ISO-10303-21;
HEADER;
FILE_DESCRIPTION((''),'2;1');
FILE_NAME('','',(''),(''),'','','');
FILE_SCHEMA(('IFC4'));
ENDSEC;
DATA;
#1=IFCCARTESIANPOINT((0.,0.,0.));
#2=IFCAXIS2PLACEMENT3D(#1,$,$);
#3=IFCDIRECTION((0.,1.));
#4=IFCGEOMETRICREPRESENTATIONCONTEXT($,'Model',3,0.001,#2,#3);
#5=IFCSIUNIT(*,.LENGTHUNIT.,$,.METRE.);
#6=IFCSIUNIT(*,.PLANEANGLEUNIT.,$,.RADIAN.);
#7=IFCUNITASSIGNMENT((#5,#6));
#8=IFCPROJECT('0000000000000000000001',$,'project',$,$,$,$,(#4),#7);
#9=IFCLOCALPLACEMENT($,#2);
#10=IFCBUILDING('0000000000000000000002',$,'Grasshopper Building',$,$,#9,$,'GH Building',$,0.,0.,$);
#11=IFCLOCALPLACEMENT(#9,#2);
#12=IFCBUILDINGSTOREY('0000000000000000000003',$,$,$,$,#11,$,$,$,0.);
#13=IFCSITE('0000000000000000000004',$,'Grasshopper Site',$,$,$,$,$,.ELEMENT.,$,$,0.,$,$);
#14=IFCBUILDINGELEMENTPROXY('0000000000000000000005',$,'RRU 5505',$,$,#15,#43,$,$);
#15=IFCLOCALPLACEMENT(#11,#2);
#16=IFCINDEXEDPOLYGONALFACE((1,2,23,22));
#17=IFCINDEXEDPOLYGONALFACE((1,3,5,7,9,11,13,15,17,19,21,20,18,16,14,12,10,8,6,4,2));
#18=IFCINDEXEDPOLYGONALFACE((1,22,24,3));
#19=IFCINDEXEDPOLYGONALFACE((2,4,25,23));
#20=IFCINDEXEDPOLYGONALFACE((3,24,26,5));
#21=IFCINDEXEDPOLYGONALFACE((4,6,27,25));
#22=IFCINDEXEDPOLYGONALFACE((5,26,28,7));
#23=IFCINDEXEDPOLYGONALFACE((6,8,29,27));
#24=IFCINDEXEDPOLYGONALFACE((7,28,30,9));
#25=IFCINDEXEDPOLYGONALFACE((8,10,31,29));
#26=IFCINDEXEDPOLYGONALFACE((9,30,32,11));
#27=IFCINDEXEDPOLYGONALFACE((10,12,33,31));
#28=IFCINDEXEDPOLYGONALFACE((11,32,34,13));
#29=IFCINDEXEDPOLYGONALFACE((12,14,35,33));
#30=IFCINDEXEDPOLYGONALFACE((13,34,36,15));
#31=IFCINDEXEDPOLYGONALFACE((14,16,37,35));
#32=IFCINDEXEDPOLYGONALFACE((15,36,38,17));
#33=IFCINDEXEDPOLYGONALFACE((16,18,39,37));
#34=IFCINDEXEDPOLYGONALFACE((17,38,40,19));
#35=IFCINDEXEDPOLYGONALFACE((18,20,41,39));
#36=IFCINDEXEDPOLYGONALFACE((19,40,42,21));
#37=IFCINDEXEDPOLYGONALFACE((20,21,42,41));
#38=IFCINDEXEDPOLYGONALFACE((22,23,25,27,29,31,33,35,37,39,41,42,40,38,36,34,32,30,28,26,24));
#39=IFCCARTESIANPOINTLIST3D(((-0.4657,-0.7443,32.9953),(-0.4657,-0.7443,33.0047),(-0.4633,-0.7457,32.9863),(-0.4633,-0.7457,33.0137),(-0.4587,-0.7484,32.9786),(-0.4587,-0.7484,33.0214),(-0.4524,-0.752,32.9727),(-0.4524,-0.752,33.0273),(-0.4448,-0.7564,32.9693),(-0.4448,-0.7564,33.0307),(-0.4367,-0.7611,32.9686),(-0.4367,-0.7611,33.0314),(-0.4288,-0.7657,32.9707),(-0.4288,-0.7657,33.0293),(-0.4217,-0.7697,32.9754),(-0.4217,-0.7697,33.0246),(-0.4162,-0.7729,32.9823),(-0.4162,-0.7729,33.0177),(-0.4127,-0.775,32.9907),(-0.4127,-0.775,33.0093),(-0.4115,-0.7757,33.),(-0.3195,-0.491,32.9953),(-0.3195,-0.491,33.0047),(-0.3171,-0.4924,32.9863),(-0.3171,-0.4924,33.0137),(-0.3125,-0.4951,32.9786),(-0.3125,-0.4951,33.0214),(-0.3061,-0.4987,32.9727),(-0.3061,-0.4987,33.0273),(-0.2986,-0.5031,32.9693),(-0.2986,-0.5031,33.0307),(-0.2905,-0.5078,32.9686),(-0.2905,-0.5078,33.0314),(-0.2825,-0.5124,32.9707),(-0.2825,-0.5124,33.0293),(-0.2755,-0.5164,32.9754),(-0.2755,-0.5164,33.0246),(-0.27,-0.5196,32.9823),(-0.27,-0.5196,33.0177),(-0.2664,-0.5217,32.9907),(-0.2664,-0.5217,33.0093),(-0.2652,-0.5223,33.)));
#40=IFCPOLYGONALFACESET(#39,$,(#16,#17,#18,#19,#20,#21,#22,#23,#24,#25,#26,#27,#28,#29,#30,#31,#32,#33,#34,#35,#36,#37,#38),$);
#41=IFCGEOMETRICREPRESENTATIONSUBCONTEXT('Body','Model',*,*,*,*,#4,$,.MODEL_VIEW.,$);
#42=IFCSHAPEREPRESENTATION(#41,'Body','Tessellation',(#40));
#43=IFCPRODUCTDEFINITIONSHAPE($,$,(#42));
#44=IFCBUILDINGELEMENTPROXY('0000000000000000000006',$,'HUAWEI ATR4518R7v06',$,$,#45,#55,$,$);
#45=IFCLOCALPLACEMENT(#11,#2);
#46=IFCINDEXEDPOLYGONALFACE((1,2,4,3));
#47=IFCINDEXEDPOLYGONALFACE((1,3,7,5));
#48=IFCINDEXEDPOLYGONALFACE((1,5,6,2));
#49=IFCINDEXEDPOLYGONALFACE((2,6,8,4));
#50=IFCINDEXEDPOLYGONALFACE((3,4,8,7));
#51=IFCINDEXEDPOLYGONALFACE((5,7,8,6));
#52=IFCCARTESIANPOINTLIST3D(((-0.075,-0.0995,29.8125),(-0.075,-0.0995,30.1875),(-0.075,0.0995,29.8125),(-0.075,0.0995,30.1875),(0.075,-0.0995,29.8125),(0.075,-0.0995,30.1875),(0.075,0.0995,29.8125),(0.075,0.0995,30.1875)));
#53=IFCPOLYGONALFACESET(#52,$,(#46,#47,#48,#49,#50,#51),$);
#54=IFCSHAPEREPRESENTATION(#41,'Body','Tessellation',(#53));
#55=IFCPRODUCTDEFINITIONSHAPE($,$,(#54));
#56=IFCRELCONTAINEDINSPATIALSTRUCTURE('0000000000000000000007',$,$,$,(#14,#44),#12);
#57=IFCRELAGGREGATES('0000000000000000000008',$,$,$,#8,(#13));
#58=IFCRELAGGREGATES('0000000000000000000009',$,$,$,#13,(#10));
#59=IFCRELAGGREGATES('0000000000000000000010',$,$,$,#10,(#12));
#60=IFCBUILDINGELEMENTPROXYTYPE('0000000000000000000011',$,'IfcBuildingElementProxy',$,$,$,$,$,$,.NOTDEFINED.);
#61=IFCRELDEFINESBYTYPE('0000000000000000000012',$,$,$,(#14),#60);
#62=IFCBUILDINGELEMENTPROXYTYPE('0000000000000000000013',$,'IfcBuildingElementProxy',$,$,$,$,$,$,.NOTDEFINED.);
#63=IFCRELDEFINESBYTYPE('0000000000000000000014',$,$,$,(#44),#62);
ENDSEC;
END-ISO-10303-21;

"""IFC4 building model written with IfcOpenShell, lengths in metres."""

from ifc_helpers import new_model, si_unit, direction, frame, frame_2d, origin, place, context, subcontext, project, spatial, rectangle, circle, extrude, source, transform, mapped, type_object, type_shapes, element, save


model = new_model("IFC4")

# Units and contexts
model_context = context("Model", 3, precision=0.001, world=origin(), true_north=direction((0.0, 1.0)))
body_context = subcontext(model_context, "Body", "Model", "MODEL_VIEW")
ifc_project = project(units=[si_unit("LENGTHUNIT", "METRE"), si_unit("PLANEANGLEUNIT", "RADIAN")], contexts=[model_context])

# Site, building, storey
site = spatial("IfcSite", under=ifc_project, Name="Grasshopper Site", CompositionType="ELEMENT", RefElevation=0.0)
building_placement = place(None, origin())
building = spatial("IfcBuilding", under=site, at=building_placement, Name="Grasshopper Building", LongName="GH Building", ElevationOfRefHeight=0.0, ElevationOfTerrain=0.0)
storey_placement = place(building_placement, origin())
storey = spatial("IfcBuildingStorey", under=building, at=storey_placement, Elevation=0.0)

# Building element proxies
building_element_proxy_type_1 = type_object("IfcBuildingElementProxyType", Name="IfcBuildingElementProxy", PredefinedType="NOTDEFINED")
shared_shape_1 = source(origin(), body_context, "Body", "SweptSolid", [
    extrude(circle(Radius=0.0315), frame((-0.2925, -0.5066, 33.0), z_axis=(-0.5, -0.866025, 0.0), x_axis=(0.866025, -0.5, 0.0)), (0.0, 0.0, 1.0), 0.2925),
])
type_shapes(building_element_proxy_type_1, [shared_shape_1])
for number, where, name in (
    (1, (0.0, 0.0, 0.0), "RRU 5505"),
):
    element("IfcBuildingElementProxy", number, at=place(storey_placement, frame(where)), inside=storey, type_object=building_element_proxy_type_1, Name=name, context=body_context, shape_type="MappedRepresentation", body=[
        mapped(shared_shape_1, transform((0.0, 0.0, 0.0), scale=1.0)),
    ])
building_element_proxy_type_2 = type_object("IfcBuildingElementProxyType", Name="IfcBuildingElementProxy", PredefinedType="NOTDEFINED")
shared_shape_2 = source(origin(), body_context, "Body", "SweptSolid", [
    extrude(rectangle(XDim=0.375, YDim=0.199, at=frame_2d((0.0, 0.0), x_axis=(0.0, 1.0))), frame((0.075, 0.0, 30.0), z_axis=(-1.0, 0.0, 0.0), x_axis=(0.0, 1.0, 0.0)), (0.0, 0.0, 1.0), 0.15),
])
type_shapes(building_element_proxy_type_2, [shared_shape_2])
for number, where, name in (
    (2, (0.0, 0.0, 0.0), "HUAWEI ATR4518R7v06"),
):
    element("IfcBuildingElementProxy", number, at=place(storey_placement, frame(where)), inside=storey, type_object=building_element_proxy_type_2, Name=name, context=body_context, shape_type="MappedRepresentation", body=[
        mapped(shared_shape_2, transform((0.0, 0.0, 0.0), scale=1.0)),
    ])

save(model, "model.ifc")
